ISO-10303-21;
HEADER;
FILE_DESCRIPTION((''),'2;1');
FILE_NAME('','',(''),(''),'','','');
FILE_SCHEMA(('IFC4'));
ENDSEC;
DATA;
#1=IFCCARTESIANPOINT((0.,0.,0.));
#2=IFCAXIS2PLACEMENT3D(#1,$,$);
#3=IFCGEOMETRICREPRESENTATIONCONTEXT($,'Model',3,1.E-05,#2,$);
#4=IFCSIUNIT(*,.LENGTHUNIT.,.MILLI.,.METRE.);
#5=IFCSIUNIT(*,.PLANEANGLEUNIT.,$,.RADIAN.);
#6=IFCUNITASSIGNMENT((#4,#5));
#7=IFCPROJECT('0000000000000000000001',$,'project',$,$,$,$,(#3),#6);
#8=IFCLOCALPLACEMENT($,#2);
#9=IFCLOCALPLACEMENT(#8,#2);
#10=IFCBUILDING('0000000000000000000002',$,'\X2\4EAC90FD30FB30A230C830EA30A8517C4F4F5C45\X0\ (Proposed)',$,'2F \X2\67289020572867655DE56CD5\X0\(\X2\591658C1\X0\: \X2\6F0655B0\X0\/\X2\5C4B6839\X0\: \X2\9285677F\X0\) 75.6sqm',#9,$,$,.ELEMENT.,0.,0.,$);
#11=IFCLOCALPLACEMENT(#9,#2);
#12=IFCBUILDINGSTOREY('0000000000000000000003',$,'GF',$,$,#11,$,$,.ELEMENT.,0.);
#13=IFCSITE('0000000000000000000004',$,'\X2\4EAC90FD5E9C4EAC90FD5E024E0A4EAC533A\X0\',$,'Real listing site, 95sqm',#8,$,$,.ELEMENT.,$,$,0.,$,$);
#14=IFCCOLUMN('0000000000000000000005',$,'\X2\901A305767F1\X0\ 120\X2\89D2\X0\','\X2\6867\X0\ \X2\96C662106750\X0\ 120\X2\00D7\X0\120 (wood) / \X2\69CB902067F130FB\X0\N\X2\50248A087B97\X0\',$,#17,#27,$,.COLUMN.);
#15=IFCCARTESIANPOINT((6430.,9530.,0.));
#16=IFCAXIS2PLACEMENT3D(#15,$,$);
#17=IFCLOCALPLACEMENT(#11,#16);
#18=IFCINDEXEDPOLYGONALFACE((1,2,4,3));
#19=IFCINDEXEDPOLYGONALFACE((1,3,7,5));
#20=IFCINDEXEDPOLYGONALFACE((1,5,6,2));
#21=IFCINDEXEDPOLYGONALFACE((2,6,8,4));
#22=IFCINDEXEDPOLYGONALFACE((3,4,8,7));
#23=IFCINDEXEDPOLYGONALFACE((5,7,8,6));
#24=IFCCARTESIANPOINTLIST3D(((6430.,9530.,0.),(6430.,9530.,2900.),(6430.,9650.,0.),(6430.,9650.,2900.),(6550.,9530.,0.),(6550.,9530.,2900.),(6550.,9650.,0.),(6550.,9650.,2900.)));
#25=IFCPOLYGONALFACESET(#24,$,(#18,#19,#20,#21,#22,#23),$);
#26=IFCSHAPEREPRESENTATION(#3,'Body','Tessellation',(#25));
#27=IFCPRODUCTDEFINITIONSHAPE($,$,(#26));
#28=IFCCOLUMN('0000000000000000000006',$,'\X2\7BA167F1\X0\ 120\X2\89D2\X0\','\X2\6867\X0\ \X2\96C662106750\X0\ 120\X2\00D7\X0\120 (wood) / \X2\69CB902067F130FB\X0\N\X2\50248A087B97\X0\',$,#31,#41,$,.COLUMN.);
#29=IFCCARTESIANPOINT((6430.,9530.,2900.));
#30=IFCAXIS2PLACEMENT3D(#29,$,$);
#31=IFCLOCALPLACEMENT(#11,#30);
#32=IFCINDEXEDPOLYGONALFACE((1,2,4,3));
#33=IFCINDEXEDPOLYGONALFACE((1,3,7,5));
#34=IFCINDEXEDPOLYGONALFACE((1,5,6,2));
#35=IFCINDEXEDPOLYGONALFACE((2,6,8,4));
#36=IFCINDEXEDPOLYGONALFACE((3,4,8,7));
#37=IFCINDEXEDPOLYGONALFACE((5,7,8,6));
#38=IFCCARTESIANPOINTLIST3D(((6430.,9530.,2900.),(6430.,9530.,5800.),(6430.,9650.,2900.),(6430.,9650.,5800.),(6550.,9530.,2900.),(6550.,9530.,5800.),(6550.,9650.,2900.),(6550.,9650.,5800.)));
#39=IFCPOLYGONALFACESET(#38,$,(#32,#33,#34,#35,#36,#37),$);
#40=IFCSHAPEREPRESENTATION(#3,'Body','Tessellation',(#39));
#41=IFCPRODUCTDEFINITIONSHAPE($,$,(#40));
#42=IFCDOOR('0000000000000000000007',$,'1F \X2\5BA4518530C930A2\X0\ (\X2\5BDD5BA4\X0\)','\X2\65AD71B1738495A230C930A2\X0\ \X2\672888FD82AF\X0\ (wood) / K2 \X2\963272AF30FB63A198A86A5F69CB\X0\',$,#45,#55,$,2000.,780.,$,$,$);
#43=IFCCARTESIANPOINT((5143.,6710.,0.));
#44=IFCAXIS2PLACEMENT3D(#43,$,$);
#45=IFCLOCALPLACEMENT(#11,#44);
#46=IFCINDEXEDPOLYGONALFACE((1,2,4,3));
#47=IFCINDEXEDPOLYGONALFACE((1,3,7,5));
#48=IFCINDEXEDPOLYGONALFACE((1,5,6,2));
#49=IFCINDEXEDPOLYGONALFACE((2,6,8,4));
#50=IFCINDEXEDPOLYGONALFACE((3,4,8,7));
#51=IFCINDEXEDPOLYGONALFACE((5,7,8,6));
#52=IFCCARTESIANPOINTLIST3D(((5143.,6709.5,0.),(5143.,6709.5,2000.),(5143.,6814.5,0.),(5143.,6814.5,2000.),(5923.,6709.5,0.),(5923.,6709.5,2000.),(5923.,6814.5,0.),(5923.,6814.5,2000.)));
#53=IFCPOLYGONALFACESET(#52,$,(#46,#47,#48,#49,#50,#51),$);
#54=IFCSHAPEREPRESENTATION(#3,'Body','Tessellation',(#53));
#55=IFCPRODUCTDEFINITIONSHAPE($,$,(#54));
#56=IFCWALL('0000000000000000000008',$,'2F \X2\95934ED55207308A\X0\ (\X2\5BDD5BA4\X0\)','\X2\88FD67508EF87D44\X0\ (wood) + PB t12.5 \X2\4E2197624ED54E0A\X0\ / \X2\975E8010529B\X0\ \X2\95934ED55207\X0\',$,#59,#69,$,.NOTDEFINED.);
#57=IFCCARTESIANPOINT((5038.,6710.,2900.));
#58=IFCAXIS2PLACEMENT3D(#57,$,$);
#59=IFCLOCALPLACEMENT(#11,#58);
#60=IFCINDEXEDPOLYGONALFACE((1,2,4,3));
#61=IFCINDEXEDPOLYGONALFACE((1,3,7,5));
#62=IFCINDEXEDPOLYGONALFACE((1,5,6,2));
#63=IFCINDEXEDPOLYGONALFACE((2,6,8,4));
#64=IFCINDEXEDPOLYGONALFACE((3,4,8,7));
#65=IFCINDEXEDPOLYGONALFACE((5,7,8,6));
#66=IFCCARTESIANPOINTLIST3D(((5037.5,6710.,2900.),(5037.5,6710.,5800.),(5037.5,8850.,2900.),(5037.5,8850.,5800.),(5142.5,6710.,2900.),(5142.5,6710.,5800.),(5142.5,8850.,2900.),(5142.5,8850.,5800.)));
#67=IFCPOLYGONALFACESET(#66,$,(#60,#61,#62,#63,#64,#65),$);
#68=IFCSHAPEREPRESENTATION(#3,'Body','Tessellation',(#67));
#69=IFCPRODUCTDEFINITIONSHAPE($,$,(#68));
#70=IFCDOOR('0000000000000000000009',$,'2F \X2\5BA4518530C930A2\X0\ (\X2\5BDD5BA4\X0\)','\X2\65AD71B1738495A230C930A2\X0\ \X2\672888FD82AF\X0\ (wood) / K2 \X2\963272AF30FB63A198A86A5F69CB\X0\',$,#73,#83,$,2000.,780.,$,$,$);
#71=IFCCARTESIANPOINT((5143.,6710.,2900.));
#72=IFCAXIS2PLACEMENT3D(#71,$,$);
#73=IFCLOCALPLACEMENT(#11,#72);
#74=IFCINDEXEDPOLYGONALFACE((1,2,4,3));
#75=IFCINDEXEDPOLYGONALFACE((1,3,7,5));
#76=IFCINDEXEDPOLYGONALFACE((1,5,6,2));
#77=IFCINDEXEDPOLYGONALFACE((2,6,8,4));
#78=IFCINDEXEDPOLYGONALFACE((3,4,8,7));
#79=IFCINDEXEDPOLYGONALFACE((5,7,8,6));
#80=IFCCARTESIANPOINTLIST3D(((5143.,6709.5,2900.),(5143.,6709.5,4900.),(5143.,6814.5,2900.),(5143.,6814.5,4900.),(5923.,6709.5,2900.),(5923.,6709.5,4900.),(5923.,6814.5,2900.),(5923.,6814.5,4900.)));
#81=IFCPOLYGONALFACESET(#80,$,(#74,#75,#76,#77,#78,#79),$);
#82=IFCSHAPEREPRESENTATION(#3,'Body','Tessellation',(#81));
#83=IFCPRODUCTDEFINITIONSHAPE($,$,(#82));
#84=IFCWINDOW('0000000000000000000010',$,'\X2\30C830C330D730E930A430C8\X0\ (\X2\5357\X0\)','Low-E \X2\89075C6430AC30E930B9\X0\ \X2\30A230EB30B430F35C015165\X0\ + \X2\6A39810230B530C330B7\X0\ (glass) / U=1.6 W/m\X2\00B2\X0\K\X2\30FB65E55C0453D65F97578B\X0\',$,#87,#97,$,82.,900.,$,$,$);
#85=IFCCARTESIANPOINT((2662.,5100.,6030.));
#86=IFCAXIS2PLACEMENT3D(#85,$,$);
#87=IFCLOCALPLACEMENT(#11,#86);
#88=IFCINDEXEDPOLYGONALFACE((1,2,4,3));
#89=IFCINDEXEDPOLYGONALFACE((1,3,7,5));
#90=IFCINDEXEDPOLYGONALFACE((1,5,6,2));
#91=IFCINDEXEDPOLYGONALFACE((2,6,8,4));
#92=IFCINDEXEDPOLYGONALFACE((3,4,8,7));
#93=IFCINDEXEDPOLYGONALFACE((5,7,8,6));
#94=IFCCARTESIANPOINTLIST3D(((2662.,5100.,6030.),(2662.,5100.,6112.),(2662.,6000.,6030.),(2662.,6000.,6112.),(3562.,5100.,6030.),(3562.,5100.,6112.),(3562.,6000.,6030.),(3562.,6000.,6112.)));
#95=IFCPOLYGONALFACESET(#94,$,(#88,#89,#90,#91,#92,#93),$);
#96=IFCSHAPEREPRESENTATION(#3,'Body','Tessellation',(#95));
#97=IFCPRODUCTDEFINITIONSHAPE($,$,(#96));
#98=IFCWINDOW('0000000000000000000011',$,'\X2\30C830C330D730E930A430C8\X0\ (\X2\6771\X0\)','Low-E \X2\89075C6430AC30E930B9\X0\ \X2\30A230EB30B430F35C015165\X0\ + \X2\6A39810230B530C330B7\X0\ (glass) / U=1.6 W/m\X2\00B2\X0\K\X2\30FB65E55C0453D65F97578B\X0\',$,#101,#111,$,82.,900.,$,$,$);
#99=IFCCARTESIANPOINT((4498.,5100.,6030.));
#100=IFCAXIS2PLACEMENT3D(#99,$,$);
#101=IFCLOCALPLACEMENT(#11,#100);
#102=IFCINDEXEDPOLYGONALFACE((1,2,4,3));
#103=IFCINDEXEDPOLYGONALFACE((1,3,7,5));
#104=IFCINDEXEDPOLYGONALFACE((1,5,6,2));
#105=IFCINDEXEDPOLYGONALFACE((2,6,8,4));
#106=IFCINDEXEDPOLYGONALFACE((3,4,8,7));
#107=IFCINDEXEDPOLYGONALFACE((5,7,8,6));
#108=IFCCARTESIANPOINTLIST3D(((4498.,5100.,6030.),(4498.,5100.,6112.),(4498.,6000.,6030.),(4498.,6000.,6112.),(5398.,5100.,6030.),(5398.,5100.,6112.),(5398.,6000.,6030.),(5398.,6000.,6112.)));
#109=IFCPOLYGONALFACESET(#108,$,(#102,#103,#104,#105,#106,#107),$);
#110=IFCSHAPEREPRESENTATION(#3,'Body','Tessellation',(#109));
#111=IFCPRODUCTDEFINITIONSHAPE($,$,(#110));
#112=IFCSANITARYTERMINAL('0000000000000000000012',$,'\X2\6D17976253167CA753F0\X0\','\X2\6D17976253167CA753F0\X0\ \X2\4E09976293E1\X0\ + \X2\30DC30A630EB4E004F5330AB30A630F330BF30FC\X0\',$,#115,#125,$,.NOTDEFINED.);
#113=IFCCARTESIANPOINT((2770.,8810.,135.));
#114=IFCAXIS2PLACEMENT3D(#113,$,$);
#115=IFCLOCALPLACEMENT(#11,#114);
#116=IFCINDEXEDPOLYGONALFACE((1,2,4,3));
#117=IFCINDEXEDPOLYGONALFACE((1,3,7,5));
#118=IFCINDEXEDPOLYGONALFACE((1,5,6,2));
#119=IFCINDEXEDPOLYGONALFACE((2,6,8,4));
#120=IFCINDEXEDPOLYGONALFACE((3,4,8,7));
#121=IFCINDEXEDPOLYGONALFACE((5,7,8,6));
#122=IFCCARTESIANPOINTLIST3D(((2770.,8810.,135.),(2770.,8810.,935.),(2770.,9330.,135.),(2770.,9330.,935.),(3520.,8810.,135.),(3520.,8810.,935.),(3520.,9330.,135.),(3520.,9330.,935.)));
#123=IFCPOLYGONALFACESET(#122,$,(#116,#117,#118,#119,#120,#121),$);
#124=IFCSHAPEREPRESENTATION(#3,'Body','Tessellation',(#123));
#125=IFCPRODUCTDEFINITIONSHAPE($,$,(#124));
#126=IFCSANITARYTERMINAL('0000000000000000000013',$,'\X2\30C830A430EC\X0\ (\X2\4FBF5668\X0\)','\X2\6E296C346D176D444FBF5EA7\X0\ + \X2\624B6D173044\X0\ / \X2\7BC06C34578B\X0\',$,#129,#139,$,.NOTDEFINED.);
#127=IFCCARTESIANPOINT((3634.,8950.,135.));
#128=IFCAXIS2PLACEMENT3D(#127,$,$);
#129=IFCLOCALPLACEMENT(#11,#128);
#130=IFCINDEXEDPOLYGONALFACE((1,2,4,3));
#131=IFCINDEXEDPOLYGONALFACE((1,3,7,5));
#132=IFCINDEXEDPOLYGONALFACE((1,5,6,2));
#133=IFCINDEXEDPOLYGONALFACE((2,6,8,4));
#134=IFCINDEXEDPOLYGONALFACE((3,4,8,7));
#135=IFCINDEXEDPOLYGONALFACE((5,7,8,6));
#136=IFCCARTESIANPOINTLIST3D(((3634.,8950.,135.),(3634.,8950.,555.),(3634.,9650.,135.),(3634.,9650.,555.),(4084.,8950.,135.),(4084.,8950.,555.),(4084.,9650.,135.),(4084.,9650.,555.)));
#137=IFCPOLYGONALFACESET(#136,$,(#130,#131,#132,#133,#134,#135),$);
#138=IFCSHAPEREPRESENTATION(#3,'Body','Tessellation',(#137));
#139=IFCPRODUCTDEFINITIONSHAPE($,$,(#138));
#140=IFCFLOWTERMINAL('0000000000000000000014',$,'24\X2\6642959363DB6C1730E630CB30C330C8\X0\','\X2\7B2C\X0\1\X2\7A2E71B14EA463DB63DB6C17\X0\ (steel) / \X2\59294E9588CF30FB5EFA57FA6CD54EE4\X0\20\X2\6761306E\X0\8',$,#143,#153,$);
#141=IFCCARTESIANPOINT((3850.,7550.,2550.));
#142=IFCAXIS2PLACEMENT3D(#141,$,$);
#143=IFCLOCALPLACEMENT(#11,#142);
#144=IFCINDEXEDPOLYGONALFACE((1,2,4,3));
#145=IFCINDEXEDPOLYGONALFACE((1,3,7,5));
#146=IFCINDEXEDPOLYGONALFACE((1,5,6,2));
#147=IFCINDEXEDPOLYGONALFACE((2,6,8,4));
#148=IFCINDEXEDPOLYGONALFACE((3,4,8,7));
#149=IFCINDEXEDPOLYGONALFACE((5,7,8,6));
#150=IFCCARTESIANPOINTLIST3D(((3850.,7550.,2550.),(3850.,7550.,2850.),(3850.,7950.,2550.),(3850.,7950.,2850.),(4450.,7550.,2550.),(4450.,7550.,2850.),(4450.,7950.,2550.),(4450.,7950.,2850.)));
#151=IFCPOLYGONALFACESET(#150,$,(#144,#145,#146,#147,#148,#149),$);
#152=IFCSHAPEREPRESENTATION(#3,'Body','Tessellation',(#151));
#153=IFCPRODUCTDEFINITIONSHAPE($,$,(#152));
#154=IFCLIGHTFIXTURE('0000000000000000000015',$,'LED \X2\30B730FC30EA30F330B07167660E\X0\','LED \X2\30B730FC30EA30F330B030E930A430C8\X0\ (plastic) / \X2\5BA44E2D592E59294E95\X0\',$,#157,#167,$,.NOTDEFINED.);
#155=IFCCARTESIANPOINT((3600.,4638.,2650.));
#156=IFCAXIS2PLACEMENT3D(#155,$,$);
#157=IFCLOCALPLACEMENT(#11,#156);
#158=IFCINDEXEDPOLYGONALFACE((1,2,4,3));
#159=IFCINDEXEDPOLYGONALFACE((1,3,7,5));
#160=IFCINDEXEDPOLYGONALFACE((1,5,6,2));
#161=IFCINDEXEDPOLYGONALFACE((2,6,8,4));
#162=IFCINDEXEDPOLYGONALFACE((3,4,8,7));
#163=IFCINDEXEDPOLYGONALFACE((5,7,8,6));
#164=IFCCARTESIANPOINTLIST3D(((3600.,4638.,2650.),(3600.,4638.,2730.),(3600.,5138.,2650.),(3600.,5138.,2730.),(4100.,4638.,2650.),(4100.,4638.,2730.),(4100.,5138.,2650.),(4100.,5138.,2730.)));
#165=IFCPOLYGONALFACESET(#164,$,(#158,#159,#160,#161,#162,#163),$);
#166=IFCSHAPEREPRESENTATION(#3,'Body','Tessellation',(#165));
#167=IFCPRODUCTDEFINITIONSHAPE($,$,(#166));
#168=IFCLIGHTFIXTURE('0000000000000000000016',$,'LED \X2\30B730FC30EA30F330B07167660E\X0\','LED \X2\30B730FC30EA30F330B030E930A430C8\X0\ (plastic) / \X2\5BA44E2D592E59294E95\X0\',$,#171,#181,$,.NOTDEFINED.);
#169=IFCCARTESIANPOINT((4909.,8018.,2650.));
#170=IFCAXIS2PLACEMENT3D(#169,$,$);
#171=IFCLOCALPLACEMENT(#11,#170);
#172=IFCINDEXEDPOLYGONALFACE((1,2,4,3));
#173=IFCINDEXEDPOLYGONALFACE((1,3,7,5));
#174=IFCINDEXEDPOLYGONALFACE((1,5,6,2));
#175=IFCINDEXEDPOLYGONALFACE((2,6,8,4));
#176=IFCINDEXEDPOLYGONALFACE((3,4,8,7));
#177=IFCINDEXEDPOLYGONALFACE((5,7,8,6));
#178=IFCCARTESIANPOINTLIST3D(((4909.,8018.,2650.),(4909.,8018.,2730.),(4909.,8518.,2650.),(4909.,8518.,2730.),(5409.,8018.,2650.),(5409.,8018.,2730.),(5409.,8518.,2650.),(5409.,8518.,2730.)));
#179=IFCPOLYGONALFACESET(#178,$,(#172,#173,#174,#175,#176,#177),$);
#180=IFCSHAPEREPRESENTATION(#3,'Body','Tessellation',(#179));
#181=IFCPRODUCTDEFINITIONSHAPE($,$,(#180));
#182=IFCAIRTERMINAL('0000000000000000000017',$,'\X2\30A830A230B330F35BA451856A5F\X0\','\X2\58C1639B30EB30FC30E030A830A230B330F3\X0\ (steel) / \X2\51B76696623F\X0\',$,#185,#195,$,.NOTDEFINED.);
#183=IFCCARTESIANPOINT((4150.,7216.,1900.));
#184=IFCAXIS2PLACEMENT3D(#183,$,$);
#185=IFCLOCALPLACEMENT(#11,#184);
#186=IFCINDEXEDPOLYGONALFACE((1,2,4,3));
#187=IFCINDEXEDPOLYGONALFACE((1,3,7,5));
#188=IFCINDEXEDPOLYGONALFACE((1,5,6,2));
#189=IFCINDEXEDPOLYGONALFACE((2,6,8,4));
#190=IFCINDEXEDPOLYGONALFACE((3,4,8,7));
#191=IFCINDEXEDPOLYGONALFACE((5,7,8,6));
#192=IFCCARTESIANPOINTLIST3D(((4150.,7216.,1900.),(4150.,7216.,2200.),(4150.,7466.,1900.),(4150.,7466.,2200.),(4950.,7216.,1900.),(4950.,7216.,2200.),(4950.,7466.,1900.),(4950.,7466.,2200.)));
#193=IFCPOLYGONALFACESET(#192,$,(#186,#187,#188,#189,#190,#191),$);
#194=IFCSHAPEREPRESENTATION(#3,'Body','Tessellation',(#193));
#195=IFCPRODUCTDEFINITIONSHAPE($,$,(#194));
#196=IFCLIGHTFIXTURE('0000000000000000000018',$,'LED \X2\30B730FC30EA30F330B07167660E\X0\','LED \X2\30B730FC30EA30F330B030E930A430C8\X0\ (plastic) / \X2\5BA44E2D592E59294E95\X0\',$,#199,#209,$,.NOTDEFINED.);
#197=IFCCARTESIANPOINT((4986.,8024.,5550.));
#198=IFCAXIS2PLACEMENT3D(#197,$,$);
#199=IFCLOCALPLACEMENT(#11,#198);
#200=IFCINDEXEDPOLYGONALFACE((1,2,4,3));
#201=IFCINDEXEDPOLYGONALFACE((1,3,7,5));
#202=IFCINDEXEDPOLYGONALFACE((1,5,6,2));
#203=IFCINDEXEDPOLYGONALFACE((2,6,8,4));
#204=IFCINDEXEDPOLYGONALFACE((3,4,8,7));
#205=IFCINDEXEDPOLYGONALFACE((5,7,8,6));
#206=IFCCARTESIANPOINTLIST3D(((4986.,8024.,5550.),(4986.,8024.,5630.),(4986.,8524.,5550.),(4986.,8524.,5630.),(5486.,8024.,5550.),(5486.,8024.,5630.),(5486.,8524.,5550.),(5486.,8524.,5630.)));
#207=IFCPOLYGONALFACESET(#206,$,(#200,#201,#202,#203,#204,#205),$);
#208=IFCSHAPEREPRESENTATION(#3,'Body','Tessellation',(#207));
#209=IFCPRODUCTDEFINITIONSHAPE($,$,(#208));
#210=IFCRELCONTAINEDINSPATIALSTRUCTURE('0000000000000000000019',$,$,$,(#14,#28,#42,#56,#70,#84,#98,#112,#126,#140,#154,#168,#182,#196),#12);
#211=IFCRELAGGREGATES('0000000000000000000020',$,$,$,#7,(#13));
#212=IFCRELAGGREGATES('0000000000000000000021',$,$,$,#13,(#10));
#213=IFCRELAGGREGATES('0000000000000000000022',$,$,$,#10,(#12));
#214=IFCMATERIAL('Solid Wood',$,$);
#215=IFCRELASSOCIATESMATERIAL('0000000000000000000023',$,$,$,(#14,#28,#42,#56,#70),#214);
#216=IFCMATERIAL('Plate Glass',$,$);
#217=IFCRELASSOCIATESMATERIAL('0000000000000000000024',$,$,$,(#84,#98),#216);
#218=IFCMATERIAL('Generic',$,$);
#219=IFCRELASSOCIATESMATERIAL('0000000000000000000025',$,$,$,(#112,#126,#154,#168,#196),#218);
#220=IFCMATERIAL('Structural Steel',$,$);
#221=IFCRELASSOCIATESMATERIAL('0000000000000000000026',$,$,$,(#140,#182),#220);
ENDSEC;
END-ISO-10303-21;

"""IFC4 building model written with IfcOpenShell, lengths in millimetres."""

from ifc_helpers import new_model, si_unit, frame, frame_2d, origin, place, context, project, spatial, rectangle, extrude, material, element, save


model = new_model("IFC4")

# Units and contexts
model_context = context("Model", 3, precision=1e-05, world=origin())
ifc_project = project(units=[si_unit("LENGTHUNIT", "METRE", prefix="MILLI"), si_unit("PLANEANGLEUNIT", "RADIAN")], contexts=[model_context])

# Site, building, storey
site_placement = place(None, origin())
site = spatial("IfcSite", under=ifc_project, at=site_placement, Name="京都府京都市上京区", ObjectType="Real listing site, 95sqm", CompositionType="ELEMENT", RefElevation=0.0)
building_placement = place(site_placement, origin())
building = spatial("IfcBuilding", under=site, at=building_placement, Name="京都・アトリエ兼住居 (Proposed)", ObjectType="2F 木造在来工法(外壁: 漆喰/屋根: 銅板) 75.6sqm", CompositionType="ELEMENT", ElevationOfRefHeight=0.0, ElevationOfTerrain=0.0)
storey_placement = place(building_placement, origin())
storey = spatial("IfcBuildingStorey", under=building, at=storey_placement, Name="GF", CompositionType="ELEMENT", Elevation=0.0)

# Columns
ifc_material_1 = material(Name="Solid Wood")
column_1_placement = place(storey_placement, frame((6430.0, 9530.0, 0.0)))
element("IfcColumn", 1, at=column_1_placement, inside=storey, material=ifc_material_1, Name="通し柱 120角", Description="桧 集成材 120×120 (wood) / 構造柱・N値計算", PredefinedType="COLUMN", context=model_context, shape_type="SweptSolid", body=[
    extrude(rectangle(XDim=120.0, YDim=120.0, at=frame_2d((60.0, 60.0))), frame((6430.0, 9530.0, 0.0)), (0.0, 0.0, 1.0), 2900.0),
])
column_2_placement = place(storey_placement, frame((6430.0, 9530.0, 2900.0)))
element("IfcColumn", 2, at=column_2_placement, inside=storey, material=ifc_material_1, Name="管柱 120角", Description="桧 集成材 120×120 (wood) / 構造柱・N値計算", PredefinedType="COLUMN", context=model_context, shape_type="SweptSolid", body=[
    extrude(rectangle(XDim=120.0, YDim=120.0, at=frame_2d((60.0, 60.0))), frame((6430.0, 9530.0, 2900.0)), (0.0, 0.0, 1.0), 2900.0),
])

# Door
door_1_placement = place(storey_placement, frame((5143.0, 6710.0, 0.0)))
element("IfcDoor", 3, at=door_1_placement, inside=storey, material=ifc_material_1, Name="1F 室内ドア (寝室)", Description="断熱玄関ドア 木製芯 (wood) / K2 防犯・採風機構", OverallHeight=2000.0, OverallWidth=780.0, context=model_context, shape_type="SweptSolid", body=[
    extrude(rectangle(XDim=780.0, YDim=105.0, at=frame_2d((390.0, 52.0))), frame((5143.0, 6710.0, 0.0)), (0.0, 0.0, 1.0), 2000.0),
])

# Wall
wall_1_placement = place(storey_placement, frame((5038.0, 6710.0, 2900.0)))
element("IfcWall", 4, at=wall_1_placement, inside=storey, material=ifc_material_1, Name="2F 間仕切り (寝室)", Description="製材軸組 (wood) + PB t12.5 両面仕上 / 非耐力 間仕切", PredefinedType="NOTDEFINED", context=model_context, shape_type="SweptSolid", body=[
    extrude(rectangle(XDim=105.0, YDim=2140.0, at=frame_2d((52.0, 1070.0))), frame((5038.0, 6710.0, 2900.0)), (0.0, 0.0, 1.0), 2900.0),
])

# Door
door_2_placement = place(storey_placement, frame((5143.0, 6710.0, 2900.0)))
element("IfcDoor", 5, at=door_2_placement, inside=storey, material=ifc_material_1, Name="2F 室内ドア (寝室)", Description="断熱玄関ドア 木製芯 (wood) / K2 防犯・採風機構", OverallHeight=2000.0, OverallWidth=780.0, context=model_context, shape_type="SweptSolid", body=[
    extrude(rectangle(XDim=780.0, YDim=105.0, at=frame_2d((390.0, 52.0))), frame((5143.0, 6710.0, 2900.0)), (0.0, 0.0, 1.0), 2000.0),
])

# Windows
ifc_material_2 = material(Name="Plate Glass")
window_1_placement = place(storey_placement, frame((2662.0, 5100.0, 6030.0)))
element("IfcWindow", 6, at=window_1_placement, inside=storey, material=ifc_material_2, Name="トップライト (南)", Description="Low-E 複層ガラス アルゴン封入 + 樹脂サッシ (glass) / U=1.6 W/m²K・日射取得型", OverallHeight=82.0, OverallWidth=900.0, context=model_context, shape_type="SweptSolid", body=[
    extrude(rectangle(XDim=900.0, YDim=900.0, at=frame_2d((450.0, 450.0))), frame((2662.0, 5100.0, 6030.0)), (0.0, 0.0, 1.0), 82.0),
])
window_2_placement = place(storey_placement, frame((4498.0, 5100.0, 6030.0)))
element("IfcWindow", 7, at=window_2_placement, inside=storey, material=ifc_material_2, Name="トップライト (東)", Description="Low-E 複層ガラス アルゴン封入 + 樹脂サッシ (glass) / U=1.6 W/m²K・日射取得型", OverallHeight=82.0, OverallWidth=900.0, context=model_context, shape_type="SweptSolid", body=[
    extrude(rectangle(XDim=900.0, YDim=900.0, at=frame_2d((450.0, 450.0))), frame((4498.0, 5100.0, 6030.0)), (0.0, 0.0, 1.0), 82.0),
])

# Sanitary terminals
ifc_material_3 = material(Name="Generic")
sanitary_terminal_1_placement = place(storey_placement, frame((2770.0, 8810.0, 135.0)))
element("IfcSanitaryTerminal", 8, at=sanitary_terminal_1_placement, inside=storey, material=ifc_material_3, Name="洗面化粧台", Description="洗面化粧台 三面鏡 + ボウル一体カウンター", PredefinedType="NOTDEFINED", context=model_context, shape_type="SweptSolid", body=[
    extrude(rectangle(XDim=750.0, YDim=520.0, at=frame_2d((375.0, 260.0))), frame((2770.0, 8810.0, 135.0)), (0.0, 0.0, 1.0), 800.0),
])
sanitary_terminal_2_placement = place(storey_placement, frame((3634.0, 8950.0, 135.0)))
element("IfcSanitaryTerminal", 9, at=sanitary_terminal_2_placement, inside=storey, material=ifc_material_3, Name="トイレ (便器)", Description="温水洗浄便座 + 手洗い / 節水型", PredefinedType="NOTDEFINED", context=model_context, shape_type="SweptSolid", body=[
    extrude(rectangle(XDim=450.0, YDim=700.0, at=frame_2d((225.0, 350.0))), frame((3634.0, 8950.0, 135.0)), (0.0, 0.0, 1.0), 420.0),
])

# Flow terminal
ifc_material_4 = material(Name="Structural Steel")
flow_terminal_placement = place(storey_placement, frame((3850.0, 7550.0, 2550.0)))
element("IfcFlowTerminal", 10, at=flow_terminal_placement, inside=storey, material=ifc_material_4, Name="24時間換気ユニット", Description="第1種熱交換換気 (steel) / 天井裏・建基法令20条の8", context=model_context, shape_type="SweptSolid", body=[
    extrude(rectangle(XDim=600.0, YDim=400.0, at=frame_2d((300.0, 200.0))), frame((3850.0, 7550.0, 2550.0)), (0.0, 0.0, 1.0), 300.0),
])

# Light fixtures
light_fixture_1_placement = place(storey_placement, frame((3600.0, 4638.0, 2650.0)))
element("IfcLightFixture", 11, at=light_fixture_1_placement, inside=storey, material=ifc_material_3, Name="LED シーリング照明", Description="LED シーリングライト (plastic) / 室中央天井", PredefinedType="NOTDEFINED", context=model_context, shape_type="SweptSolid", body=[
    extrude(rectangle(XDim=500.0, YDim=500.0, at=frame_2d((250.0, 250.0))), frame((3600.0, 4638.0, 2650.0)), (0.0, 0.0, 1.0), 80.0),
])
light_fixture_2_placement = place(storey_placement, frame((4909.0, 8018.0, 2650.0)))
element("IfcLightFixture", 12, at=light_fixture_2_placement, inside=storey, material=ifc_material_3, Name="LED シーリング照明", Description="LED シーリングライト (plastic) / 室中央天井", PredefinedType="NOTDEFINED", context=model_context, shape_type="SweptSolid", body=[
    extrude(rectangle(XDim=500.0, YDim=500.0, at=frame_2d((250.0, 250.0))), frame((4909.0, 8018.0, 2650.0)), (0.0, 0.0, 1.0), 80.0),
])

# Air terminal
air_terminal_placement = place(storey_placement, frame((4150.0, 7216.0, 1900.0)))
element("IfcAirTerminal", 13, at=air_terminal_placement, inside=storey, material=ifc_material_4, Name="エアコン室内機", Description="壁掛ルームエアコン (steel) / 冷暖房", PredefinedType="NOTDEFINED", context=model_context, shape_type="SweptSolid", body=[
    extrude(rectangle(XDim=800.0, YDim=250.0, at=frame_2d((400.0, 125.0))), frame((4150.0, 7216.0, 1900.0)), (0.0, 0.0, 1.0), 300.0),
])

# Light fixture
light_fixture_3_placement = place(storey_placement, frame((4986.0, 8024.0, 5550.0)))
element("IfcLightFixture", 14, at=light_fixture_3_placement, inside=storey, material=ifc_material_3, Name="LED シーリング照明", Description="LED シーリングライト (plastic) / 室中央天井", PredefinedType="NOTDEFINED", context=model_context, shape_type="SweptSolid", body=[
    extrude(rectangle(XDim=500.0, YDim=500.0, at=frame_2d((250.0, 250.0))), frame((4986.0, 8024.0, 5550.0)), (0.0, 0.0, 1.0), 80.0),
])

save(model, "model.ifc")
